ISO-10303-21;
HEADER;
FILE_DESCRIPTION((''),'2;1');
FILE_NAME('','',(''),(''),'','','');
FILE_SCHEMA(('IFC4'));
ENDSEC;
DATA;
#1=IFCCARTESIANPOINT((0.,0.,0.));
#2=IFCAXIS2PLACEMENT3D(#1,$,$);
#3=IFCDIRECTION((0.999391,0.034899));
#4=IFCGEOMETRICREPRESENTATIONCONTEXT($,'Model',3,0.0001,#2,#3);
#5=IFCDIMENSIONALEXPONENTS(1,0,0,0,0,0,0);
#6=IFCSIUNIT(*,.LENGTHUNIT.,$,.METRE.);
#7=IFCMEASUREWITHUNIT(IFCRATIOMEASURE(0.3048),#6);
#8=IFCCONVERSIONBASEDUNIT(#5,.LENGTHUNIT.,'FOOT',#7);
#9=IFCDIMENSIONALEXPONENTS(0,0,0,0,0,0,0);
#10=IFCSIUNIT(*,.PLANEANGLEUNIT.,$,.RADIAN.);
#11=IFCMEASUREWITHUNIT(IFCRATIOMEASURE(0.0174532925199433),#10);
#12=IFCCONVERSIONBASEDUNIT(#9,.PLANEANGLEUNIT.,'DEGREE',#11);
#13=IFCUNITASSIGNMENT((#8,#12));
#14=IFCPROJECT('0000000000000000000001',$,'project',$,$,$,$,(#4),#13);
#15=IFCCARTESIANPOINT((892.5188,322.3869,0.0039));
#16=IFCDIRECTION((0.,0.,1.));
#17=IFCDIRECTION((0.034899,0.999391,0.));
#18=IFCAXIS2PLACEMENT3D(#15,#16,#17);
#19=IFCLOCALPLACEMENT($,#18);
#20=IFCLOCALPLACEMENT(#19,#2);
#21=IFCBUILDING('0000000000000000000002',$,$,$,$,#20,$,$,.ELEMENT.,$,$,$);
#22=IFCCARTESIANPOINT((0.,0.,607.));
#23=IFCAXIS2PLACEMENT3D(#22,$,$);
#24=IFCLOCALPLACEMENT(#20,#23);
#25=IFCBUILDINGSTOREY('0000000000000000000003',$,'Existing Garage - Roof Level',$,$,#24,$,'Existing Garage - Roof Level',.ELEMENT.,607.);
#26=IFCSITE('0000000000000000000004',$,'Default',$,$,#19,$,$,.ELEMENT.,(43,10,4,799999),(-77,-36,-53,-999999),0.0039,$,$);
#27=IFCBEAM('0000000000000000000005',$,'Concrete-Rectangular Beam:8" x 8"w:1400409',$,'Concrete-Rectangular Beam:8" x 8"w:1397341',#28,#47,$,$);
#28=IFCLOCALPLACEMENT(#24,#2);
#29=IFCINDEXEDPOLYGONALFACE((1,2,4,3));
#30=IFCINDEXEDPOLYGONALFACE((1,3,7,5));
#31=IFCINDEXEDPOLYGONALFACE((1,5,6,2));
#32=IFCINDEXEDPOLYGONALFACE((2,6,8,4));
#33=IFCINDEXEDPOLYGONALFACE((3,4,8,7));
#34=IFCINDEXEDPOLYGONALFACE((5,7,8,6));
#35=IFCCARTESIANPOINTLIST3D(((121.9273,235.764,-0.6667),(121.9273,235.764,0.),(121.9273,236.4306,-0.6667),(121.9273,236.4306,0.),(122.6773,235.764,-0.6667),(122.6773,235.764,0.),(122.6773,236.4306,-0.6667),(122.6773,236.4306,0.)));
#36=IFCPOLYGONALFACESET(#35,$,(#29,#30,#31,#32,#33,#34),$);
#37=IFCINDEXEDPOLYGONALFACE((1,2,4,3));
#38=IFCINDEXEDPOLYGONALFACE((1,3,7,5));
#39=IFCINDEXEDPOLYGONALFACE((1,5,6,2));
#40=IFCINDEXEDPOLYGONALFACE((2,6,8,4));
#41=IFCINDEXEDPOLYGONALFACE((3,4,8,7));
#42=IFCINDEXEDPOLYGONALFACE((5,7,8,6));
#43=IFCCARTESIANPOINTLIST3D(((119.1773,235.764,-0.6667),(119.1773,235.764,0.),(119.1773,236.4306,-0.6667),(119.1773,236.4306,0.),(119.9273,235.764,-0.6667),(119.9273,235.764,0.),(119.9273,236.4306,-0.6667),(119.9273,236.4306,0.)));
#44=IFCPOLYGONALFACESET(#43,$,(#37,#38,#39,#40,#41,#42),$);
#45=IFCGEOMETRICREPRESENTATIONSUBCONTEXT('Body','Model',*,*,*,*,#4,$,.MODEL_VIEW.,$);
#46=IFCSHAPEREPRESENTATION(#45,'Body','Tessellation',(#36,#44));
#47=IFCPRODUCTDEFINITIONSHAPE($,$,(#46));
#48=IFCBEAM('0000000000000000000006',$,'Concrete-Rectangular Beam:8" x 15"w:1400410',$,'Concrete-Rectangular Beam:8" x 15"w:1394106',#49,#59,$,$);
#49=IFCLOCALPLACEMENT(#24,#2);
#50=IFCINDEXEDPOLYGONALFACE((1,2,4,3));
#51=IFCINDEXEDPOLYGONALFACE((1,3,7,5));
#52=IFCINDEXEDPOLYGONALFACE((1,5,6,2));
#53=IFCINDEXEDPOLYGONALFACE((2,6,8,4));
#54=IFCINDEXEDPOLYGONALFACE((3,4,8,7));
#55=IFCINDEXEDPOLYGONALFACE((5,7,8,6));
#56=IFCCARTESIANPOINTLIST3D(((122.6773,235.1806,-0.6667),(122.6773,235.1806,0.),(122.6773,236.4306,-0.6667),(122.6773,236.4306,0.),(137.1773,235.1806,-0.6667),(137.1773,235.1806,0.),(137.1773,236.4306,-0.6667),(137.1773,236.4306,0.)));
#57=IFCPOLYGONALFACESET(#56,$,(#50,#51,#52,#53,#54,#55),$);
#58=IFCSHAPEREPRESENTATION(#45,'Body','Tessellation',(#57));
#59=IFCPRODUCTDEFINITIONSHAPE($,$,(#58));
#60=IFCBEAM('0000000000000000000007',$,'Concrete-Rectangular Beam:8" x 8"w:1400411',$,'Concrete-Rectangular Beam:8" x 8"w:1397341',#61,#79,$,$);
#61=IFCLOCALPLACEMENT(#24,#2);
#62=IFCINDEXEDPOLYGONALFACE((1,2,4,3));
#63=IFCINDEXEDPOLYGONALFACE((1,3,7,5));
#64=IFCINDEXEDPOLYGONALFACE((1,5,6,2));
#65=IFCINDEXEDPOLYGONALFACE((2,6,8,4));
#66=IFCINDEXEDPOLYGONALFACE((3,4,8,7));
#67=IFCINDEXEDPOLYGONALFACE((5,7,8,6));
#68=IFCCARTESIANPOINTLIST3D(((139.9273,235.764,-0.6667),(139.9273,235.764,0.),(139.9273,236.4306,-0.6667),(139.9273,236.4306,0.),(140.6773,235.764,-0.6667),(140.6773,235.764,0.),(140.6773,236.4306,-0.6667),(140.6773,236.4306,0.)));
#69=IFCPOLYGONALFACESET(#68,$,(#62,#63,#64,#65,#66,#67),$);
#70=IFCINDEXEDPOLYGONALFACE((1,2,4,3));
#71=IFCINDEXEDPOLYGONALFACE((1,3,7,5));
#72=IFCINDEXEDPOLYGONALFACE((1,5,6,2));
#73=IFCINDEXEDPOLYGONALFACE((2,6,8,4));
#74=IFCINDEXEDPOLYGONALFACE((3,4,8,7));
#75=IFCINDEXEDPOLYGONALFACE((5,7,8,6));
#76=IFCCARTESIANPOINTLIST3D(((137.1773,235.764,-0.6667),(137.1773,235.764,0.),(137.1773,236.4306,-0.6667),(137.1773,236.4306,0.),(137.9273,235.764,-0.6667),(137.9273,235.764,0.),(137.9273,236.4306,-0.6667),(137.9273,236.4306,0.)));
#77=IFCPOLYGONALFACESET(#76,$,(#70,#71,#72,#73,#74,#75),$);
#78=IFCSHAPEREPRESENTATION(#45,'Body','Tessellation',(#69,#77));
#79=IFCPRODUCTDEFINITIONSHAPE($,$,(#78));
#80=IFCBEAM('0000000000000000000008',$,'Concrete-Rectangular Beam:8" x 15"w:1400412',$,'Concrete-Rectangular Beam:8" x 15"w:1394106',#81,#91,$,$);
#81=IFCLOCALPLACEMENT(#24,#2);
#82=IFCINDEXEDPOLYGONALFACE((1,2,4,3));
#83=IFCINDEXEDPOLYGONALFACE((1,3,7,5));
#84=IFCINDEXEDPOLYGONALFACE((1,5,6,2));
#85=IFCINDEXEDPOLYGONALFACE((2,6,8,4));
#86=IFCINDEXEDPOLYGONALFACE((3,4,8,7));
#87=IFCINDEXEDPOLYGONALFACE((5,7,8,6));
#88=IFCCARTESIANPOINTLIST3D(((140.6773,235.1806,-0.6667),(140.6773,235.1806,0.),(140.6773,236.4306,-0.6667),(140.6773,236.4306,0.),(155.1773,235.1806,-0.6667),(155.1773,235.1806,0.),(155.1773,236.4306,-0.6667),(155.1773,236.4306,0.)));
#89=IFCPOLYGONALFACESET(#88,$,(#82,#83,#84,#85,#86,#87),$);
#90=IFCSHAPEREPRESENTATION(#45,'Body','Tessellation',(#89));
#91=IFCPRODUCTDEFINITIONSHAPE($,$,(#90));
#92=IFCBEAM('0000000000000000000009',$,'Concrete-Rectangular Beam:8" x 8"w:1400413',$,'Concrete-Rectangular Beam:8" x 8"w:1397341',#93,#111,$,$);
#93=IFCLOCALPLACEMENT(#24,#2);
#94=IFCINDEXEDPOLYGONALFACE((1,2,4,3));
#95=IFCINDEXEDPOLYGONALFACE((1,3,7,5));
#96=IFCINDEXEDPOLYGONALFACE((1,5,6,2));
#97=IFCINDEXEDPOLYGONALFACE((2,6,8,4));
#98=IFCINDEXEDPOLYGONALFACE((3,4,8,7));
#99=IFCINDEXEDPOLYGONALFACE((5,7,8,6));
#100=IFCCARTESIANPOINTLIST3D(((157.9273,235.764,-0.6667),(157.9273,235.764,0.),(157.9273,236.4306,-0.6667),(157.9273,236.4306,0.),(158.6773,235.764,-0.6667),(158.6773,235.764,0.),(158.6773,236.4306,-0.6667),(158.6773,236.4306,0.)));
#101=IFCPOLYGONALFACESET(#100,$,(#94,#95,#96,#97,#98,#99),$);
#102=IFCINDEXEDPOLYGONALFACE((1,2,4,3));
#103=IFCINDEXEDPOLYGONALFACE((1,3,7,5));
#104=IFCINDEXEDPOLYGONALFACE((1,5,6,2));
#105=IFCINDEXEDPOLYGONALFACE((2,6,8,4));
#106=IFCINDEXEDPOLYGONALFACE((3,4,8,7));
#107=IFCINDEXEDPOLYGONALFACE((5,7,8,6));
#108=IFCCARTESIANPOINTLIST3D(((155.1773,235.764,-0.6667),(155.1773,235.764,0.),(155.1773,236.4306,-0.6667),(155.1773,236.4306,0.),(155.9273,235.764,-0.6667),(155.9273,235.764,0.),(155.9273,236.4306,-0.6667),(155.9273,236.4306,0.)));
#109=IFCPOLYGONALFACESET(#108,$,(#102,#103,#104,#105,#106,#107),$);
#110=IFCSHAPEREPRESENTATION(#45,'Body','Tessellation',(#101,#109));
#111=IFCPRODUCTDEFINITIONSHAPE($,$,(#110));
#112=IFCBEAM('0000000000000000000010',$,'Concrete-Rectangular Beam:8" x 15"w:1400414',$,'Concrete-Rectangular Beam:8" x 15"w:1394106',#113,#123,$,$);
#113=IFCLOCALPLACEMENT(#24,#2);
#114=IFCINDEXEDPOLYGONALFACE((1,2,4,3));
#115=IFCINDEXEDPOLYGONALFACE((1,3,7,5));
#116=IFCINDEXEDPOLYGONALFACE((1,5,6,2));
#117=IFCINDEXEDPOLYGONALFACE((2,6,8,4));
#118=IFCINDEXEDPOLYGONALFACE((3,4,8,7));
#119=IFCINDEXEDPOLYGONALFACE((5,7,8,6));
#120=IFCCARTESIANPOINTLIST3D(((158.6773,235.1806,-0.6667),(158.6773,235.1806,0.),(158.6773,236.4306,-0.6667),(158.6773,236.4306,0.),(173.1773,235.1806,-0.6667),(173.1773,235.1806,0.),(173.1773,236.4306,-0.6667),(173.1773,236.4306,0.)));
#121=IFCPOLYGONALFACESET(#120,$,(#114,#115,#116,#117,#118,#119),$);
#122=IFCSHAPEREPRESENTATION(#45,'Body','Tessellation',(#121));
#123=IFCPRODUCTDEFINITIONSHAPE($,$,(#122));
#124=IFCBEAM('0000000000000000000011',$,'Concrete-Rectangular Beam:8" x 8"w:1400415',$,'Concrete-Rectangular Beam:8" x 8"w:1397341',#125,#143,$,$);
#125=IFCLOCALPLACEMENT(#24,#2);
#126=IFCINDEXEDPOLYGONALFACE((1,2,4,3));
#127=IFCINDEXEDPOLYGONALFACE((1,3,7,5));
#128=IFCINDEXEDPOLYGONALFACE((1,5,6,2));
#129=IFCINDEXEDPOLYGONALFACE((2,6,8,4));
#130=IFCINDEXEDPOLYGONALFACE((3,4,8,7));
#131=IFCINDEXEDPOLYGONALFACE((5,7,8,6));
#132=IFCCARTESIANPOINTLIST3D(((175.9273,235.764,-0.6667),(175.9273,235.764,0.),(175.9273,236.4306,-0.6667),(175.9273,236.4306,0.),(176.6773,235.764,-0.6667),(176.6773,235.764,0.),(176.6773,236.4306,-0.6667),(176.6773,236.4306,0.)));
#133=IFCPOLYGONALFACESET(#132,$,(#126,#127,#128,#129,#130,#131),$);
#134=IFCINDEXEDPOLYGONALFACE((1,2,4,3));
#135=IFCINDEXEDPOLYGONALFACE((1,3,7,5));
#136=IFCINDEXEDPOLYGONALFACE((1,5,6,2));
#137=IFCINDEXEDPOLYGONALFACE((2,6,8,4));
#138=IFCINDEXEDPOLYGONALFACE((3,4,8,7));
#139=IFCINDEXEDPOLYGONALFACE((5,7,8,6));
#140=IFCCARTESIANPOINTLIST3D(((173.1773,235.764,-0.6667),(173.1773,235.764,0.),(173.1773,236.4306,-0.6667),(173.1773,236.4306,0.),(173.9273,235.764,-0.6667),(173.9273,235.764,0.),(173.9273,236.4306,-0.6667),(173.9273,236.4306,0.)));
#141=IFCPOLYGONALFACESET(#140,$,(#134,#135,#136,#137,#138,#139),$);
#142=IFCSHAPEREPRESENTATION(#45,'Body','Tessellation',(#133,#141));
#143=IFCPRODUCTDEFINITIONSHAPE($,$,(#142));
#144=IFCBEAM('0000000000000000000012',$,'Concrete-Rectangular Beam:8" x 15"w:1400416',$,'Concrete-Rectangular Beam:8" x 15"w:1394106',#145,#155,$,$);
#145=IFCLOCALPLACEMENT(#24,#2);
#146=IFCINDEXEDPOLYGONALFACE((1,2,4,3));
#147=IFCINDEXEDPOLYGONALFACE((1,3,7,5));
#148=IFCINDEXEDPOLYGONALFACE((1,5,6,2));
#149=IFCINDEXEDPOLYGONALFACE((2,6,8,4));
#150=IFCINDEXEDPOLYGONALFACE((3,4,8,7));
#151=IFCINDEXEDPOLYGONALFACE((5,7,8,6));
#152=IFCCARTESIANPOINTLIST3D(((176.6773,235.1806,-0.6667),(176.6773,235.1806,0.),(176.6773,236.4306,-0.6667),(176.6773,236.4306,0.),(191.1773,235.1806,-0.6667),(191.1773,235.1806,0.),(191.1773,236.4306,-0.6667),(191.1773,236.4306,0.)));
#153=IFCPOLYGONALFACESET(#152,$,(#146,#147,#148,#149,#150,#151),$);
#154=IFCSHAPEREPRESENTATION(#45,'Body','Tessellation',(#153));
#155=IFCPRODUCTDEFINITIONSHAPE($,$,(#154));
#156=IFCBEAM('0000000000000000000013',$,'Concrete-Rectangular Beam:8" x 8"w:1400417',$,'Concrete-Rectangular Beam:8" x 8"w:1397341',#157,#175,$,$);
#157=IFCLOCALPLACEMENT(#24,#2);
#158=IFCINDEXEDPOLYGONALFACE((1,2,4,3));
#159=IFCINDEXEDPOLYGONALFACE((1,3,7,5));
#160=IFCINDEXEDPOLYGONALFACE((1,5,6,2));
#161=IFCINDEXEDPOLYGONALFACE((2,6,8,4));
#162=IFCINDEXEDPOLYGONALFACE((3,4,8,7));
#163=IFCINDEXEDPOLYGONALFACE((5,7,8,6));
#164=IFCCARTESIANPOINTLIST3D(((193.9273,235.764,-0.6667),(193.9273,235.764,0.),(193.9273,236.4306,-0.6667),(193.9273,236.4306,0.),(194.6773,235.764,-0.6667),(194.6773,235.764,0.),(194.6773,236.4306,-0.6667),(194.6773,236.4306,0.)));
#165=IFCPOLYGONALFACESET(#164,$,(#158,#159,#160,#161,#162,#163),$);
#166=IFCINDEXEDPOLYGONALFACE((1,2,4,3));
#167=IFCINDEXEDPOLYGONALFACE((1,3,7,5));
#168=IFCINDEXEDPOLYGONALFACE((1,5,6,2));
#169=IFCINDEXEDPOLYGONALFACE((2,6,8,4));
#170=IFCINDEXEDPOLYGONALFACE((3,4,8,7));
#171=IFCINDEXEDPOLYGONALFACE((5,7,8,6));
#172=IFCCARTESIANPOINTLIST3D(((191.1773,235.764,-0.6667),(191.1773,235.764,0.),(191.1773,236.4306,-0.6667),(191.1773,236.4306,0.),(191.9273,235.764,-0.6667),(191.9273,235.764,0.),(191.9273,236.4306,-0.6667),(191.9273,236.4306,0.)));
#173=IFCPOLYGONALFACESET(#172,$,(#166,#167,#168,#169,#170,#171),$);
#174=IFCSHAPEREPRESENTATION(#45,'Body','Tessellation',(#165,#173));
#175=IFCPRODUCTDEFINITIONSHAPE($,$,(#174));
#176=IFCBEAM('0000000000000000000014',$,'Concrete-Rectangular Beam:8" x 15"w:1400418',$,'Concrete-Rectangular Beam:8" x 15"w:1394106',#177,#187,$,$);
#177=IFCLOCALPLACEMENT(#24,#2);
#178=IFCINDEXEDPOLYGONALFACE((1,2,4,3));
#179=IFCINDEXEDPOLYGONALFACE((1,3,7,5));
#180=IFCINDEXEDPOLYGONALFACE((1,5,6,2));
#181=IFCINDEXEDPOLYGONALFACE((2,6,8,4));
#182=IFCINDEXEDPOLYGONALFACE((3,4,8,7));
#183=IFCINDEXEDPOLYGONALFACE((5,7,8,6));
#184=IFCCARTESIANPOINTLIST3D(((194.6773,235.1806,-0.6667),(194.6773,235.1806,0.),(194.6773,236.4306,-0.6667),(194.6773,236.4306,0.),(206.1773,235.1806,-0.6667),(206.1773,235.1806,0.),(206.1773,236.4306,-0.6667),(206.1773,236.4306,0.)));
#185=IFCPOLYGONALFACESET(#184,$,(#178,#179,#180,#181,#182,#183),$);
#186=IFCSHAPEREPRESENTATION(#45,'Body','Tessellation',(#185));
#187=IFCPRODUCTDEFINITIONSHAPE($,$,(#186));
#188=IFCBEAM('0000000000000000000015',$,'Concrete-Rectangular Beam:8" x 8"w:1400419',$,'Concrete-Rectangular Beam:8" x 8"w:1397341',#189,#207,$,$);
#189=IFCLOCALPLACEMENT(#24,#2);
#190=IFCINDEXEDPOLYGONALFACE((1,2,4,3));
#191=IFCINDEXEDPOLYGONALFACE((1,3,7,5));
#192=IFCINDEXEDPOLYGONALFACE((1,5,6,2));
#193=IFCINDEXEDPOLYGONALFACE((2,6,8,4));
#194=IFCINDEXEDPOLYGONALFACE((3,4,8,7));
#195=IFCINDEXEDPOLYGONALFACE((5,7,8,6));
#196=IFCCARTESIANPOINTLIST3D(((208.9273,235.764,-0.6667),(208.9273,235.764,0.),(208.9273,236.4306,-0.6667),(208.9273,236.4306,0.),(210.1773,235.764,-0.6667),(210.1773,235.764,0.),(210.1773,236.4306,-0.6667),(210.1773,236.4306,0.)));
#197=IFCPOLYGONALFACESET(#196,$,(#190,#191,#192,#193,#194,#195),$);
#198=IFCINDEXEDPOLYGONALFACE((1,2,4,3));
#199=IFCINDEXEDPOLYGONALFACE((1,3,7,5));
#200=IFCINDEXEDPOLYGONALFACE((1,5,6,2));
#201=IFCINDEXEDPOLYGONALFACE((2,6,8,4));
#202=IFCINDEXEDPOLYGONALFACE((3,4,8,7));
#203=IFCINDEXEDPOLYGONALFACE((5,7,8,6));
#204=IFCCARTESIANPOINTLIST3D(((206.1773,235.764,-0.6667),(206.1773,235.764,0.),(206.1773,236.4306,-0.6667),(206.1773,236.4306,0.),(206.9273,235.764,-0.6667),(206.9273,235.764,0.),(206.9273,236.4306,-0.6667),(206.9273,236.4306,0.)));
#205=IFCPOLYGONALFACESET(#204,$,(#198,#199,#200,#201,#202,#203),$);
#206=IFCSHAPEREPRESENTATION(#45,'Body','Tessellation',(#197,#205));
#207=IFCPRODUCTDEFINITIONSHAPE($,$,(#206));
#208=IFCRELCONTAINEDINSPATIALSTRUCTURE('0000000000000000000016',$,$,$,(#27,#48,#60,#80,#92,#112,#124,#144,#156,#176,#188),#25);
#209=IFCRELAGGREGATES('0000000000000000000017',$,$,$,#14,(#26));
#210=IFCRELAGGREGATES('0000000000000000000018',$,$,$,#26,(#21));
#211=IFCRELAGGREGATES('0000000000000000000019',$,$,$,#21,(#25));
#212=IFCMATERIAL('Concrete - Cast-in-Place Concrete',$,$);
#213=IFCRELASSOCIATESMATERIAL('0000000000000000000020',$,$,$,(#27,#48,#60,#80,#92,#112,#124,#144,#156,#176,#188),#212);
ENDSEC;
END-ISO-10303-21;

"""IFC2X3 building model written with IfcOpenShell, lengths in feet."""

from ifc_helpers import new_model, entity, si_unit, converted_unit, direction, frame, frame_2d, origin, origin_2d_with_axis, place, context, subcontext, project, spatial, rectangle, extrude, material, element, save


model = new_model("IFC2X3")

# Units and contexts
model_context = context("Model", 3, precision=0.0001, world=origin(), true_north=direction((0.999391, 0.034899)))
body_context = subcontext(model_context, "Body", "Model", "MODEL_VIEW")
ifc_project = project(units=[converted_unit("LENGTHUNIT", "FOOT", entity("IfcRatioMeasure", 0.3048), si_unit("LENGTHUNIT", "METRE"), dimensions=[1, 0, 0, 0, 0, 0, 0]), converted_unit("PLANEANGLEUNIT", "DEGREE", entity("IfcRatioMeasure", 0.0174532925199433), si_unit("PLANEANGLEUNIT", "RADIAN"), dimensions=[0, 0, 0, 0, 0, 0, 0])], contexts=[model_context])

# Site, building, storey
site_placement = place(None, frame((892.5188, 322.3869, 0.0039), z_axis=(0.0, 0.0, 1.0), x_axis=(0.034899, 0.999391, 0.0)))
site = spatial("IfcSite", under=ifc_project, at=site_placement, Name="Default", CompositionType="ELEMENT", RefLatitude=(43, 10, 4, 799999), RefLongitude=(-77, -36, -53, -999999), RefElevation=0.0039)
building_placement = place(site_placement, origin())
building = spatial("IfcBuilding", under=site, at=building_placement, CompositionType="ELEMENT")
storey_placement = place(building_placement, frame((0.0, 0.0, 607.0)))
storey = spatial("IfcBuildingStorey", under=building, at=storey_placement, Name="Existing Garage - Roof Level", LongName="Existing Garage - Roof Level", CompositionType="ELEMENT", Elevation=607.0)

# Beams
ifc_material_1 = material(Name="Concrete - Cast-in-Place Concrete")
beam_1_placement = place(storey_placement, frame((119.1773, 236.0973, 0.0)))
element("IfcBeam", 1, at=beam_1_placement, inside=storey, material=ifc_material_1, Name="Concrete-Rectangular Beam:8\" x 8\"w:1400409", ObjectType="Concrete-Rectangular Beam:8\" x 8\"w:1397341", context=body_context, shape_type="SweptSolid", body=[
    extrude(rectangle(XDim=0.6667, YDim=0.6667, at=frame_2d((0.0, 0.0), x_axis=(1.0, 0.0))), frame((2.75, 0.0, -0.3333), z_axis=(1.0, 0.0, 0.0), x_axis=(0.0, 0.0, -1.0)), (0.0, 0.0, 1.0), 0.75),
    extrude(rectangle(XDim=0.6667, YDim=0.6667, at=frame_2d((0.0, 0.0), x_axis=(0.0, 1.0))), frame((0.0, 0.0, -0.3333), z_axis=(1.0, 0.0, 0.0), x_axis=(0.0, -1.0, 0.0)), (0.0, 0.0, 1.0), 0.75),
])
beam_2_placement = place(storey_placement, frame((122.6773, 235.8056, 0.0)))
element("IfcBeam", 2, at=beam_2_placement, inside=storey, material=ifc_material_1, Name="Concrete-Rectangular Beam:8\" x 15\"w:1400410", ObjectType="Concrete-Rectangular Beam:8\" x 15\"w:1394106", context=body_context, shape_type="SweptSolid", body=[
    extrude(rectangle(XDim=0.6667, YDim=1.25, at=frame_2d((0.0, 0.0), x_axis=(1.0, 0.0))), frame((0.0, 0.0, -0.3333), z_axis=(1.0, 0.0, 0.0), x_axis=(0.0, 0.0, -1.0)), (0.0, 0.0, 1.0), 14.5),
])
beam_3_placement = place(storey_placement, frame((137.1773, 236.0973, 0.0)))
element("IfcBeam", 3, at=beam_3_placement, inside=storey, material=ifc_material_1, Name="Concrete-Rectangular Beam:8\" x 8\"w:1400411", ObjectType="Concrete-Rectangular Beam:8\" x 8\"w:1397341", context=body_context, shape_type="SweptSolid", body=[
    extrude(rectangle(XDim=0.6667, YDim=0.6667, at=frame_2d((0.0, 0.0), x_axis=(1.0, 0.0))), frame((2.75, 0.0, -0.3333), z_axis=(1.0, 0.0, 0.0), x_axis=(0.0, 0.0, -1.0)), (0.0, 0.0, 1.0), 0.75),
    extrude(rectangle(XDim=0.6667, YDim=0.6667, at=frame_2d((0.0, 0.0), x_axis=(0.0, 1.0))), frame((0.0, 0.0, -0.3333), z_axis=(1.0, 0.0, 0.0), x_axis=(0.0, -1.0, 0.0)), (0.0, 0.0, 1.0), 0.75),
])
beam_4_placement = place(storey_placement, frame((140.6773, 235.8056, 0.0)))
element("IfcBeam", 4, at=beam_4_placement, inside=storey, material=ifc_material_1, Name="Concrete-Rectangular Beam:8\" x 15\"w:1400412", ObjectType="Concrete-Rectangular Beam:8\" x 15\"w:1394106", context=body_context, shape_type="SweptSolid", body=[
    extrude(rectangle(XDim=0.6667, YDim=1.25, at=frame_2d((0.0, 0.0), x_axis=(1.0, 0.0))), frame((0.0, 0.0, -0.3333), z_axis=(1.0, 0.0, 0.0), x_axis=(0.0, 0.0, -1.0)), (0.0, 0.0, 1.0), 14.5),
])
beam_5_placement = place(storey_placement, frame((154.5106, 236.0973, 0.0)))
element("IfcBeam", 5, at=beam_5_placement, inside=storey, material=ifc_material_1, Name="Concrete-Rectangular Beam:8\" x 8\"w:1400413", ObjectType="Concrete-Rectangular Beam:8\" x 8\"w:1397341", context=body_context, shape_type="SweptSolid", body=[
    extrude(rectangle(XDim=0.6667, YDim=0.6667, at=frame_2d((0.0, 0.0), x_axis=(1.0, 0.0))), frame((3.4167, 0.0, -0.3333), z_axis=(1.0, 0.0, 0.0), x_axis=(0.0, 0.0, -1.0)), (0.0, 0.0, 1.0), 0.75),
    extrude(rectangle(XDim=0.6667, YDim=0.6667, at=frame_2d((0.0, 0.0), x_axis=(1.0, 0.0))), frame((0.6667, 0.0, -0.3333), z_axis=(1.0, 0.0, 0.0), x_axis=(0.0, 0.0, -1.0)), (0.0, 0.0, 1.0), 0.75),
])
beam_6_placement = place(storey_placement, frame((158.6773, 235.8056, 0.0)))
element("IfcBeam", 6, at=beam_6_placement, inside=storey, material=ifc_material_1, Name="Concrete-Rectangular Beam:8\" x 15\"w:1400414", ObjectType="Concrete-Rectangular Beam:8\" x 15\"w:1394106", context=body_context, shape_type="SweptSolid", body=[
    extrude(rectangle(XDim=0.6667, YDim=1.25, at=frame_2d((0.0, 0.0), x_axis=(1.0, 0.0))), frame((0.0, 0.0, -0.3333), z_axis=(1.0, 0.0, 0.0), x_axis=(0.0, 0.0, -1.0)), (0.0, 0.0, 1.0), 14.5),
])
beam_7_placement = place(storey_placement, frame((173.1773, 236.0973, 0.0)))
element("IfcBeam", 7, at=beam_7_placement, inside=storey, material=ifc_material_1, Name="Concrete-Rectangular Beam:8\" x 8\"w:1400415", ObjectType="Concrete-Rectangular Beam:8\" x 8\"w:1397341", context=body_context, shape_type="SweptSolid", body=[
    extrude(rectangle(XDim=0.6667, YDim=0.6667, at=origin_2d_with_axis()), frame((2.75, 0.0, -0.3333), z_axis=(1.0, 0.0, 0.0), x_axis=(0.0, 0.0, -1.0)), (0.0, 0.0, 1.0), 0.75),
    extrude(rectangle(XDim=0.6667, YDim=0.6667, at=frame_2d((0.0, 0.0), x_axis=(0.0, 1.0))), frame((0.0, 0.0, -0.3333), z_axis=(1.0, 0.0, 0.0), x_axis=(0.0, -1.0, 0.0)), (0.0, 0.0, 1.0), 0.75),
])
beam_8_placement = place(storey_placement, frame((176.6773, 235.8056, 0.0)))
element("IfcBeam", 8, at=beam_8_placement, inside=storey, material=ifc_material_1, Name="Concrete-Rectangular Beam:8\" x 15\"w:1400416", ObjectType="Concrete-Rectangular Beam:8\" x 15\"w:1394106", context=body_context, shape_type="SweptSolid", body=[
    extrude(rectangle(XDim=0.6667, YDim=1.25, at=frame_2d((0.0, 0.0), x_axis=(1.0, 0.0))), frame((0.0, 0.0, -0.3333), z_axis=(1.0, 0.0, 0.0), x_axis=(0.0, 0.0, -1.0)), (0.0, 0.0, 1.0), 14.5),
])
beam_9_placement = place(storey_placement, frame((191.1773, 236.0973, 0.0)))
element("IfcBeam", 9, at=beam_9_placement, inside=storey, material=ifc_material_1, Name="Concrete-Rectangular Beam:8\" x 8\"w:1400417", ObjectType="Concrete-Rectangular Beam:8\" x 8\"w:1397341", context=body_context, shape_type="SweptSolid", body=[
    extrude(rectangle(XDim=0.6667, YDim=0.6667, at=origin_2d_with_axis()), frame((2.75, 0.0, -0.3333), z_axis=(1.0, 0.0, 0.0), x_axis=(0.0, 0.0, -1.0)), (0.0, 0.0, 1.0), 0.75),
    extrude(rectangle(XDim=0.6667, YDim=0.6667, at=frame_2d((0.0, 0.0), x_axis=(0.0, 1.0))), frame((0.0, 0.0, -0.3333), z_axis=(1.0, 0.0, 0.0), x_axis=(0.0, -1.0, 0.0)), (0.0, 0.0, 1.0), 0.75),
])
beam_10_placement = place(storey_placement, frame((194.6773, 235.8056, 0.0)))
element("IfcBeam", 10, at=beam_10_placement, inside=storey, material=ifc_material_1, Name="Concrete-Rectangular Beam:8\" x 15\"w:1400418", ObjectType="Concrete-Rectangular Beam:8\" x 15\"w:1394106", context=body_context, shape_type="SweptSolid", body=[
    extrude(rectangle(XDim=0.6667, YDim=1.25, at=frame_2d((0.0, 0.0), x_axis=(1.0, 0.0))), frame((0.0, 0.0, -0.3333), z_axis=(1.0, 0.0, 0.0), x_axis=(0.0, 0.0, -1.0)), (0.0, 0.0, 1.0), 11.5),
])
beam_11_placement = place(storey_placement, frame((206.1773, 236.0973, 0.0)))
element("IfcBeam", 11, at=beam_11_placement, inside=storey, material=ifc_material_1, Name="Concrete-Rectangular Beam:8\" x 8\"w:1400419", ObjectType="Concrete-Rectangular Beam:8\" x 8\"w:1397341", context=body_context, shape_type="SweptSolid", body=[
    extrude(rectangle(XDim=0.6667, YDim=0.6667, at=frame_2d((0.0, 0.0), x_axis=(1.0, 0.0))), frame((2.75, 0.0, -0.3333), z_axis=(1.0, 0.0, 0.0), x_axis=(0.0, 0.0, -1.0)), (0.0, 0.0, 1.0), 1.25),
    extrude(rectangle(XDim=0.6667, YDim=0.6667, at=frame_2d((0.0, 0.0), x_axis=(0.0, 1.0))), frame((0.0, 0.0, -0.3333), z_axis=(1.0, 0.0, 0.0), x_axis=(0.0, -1.0, 0.0)), (0.0, 0.0, 1.0), 0.75),
])

save(model, "model.ifc")
